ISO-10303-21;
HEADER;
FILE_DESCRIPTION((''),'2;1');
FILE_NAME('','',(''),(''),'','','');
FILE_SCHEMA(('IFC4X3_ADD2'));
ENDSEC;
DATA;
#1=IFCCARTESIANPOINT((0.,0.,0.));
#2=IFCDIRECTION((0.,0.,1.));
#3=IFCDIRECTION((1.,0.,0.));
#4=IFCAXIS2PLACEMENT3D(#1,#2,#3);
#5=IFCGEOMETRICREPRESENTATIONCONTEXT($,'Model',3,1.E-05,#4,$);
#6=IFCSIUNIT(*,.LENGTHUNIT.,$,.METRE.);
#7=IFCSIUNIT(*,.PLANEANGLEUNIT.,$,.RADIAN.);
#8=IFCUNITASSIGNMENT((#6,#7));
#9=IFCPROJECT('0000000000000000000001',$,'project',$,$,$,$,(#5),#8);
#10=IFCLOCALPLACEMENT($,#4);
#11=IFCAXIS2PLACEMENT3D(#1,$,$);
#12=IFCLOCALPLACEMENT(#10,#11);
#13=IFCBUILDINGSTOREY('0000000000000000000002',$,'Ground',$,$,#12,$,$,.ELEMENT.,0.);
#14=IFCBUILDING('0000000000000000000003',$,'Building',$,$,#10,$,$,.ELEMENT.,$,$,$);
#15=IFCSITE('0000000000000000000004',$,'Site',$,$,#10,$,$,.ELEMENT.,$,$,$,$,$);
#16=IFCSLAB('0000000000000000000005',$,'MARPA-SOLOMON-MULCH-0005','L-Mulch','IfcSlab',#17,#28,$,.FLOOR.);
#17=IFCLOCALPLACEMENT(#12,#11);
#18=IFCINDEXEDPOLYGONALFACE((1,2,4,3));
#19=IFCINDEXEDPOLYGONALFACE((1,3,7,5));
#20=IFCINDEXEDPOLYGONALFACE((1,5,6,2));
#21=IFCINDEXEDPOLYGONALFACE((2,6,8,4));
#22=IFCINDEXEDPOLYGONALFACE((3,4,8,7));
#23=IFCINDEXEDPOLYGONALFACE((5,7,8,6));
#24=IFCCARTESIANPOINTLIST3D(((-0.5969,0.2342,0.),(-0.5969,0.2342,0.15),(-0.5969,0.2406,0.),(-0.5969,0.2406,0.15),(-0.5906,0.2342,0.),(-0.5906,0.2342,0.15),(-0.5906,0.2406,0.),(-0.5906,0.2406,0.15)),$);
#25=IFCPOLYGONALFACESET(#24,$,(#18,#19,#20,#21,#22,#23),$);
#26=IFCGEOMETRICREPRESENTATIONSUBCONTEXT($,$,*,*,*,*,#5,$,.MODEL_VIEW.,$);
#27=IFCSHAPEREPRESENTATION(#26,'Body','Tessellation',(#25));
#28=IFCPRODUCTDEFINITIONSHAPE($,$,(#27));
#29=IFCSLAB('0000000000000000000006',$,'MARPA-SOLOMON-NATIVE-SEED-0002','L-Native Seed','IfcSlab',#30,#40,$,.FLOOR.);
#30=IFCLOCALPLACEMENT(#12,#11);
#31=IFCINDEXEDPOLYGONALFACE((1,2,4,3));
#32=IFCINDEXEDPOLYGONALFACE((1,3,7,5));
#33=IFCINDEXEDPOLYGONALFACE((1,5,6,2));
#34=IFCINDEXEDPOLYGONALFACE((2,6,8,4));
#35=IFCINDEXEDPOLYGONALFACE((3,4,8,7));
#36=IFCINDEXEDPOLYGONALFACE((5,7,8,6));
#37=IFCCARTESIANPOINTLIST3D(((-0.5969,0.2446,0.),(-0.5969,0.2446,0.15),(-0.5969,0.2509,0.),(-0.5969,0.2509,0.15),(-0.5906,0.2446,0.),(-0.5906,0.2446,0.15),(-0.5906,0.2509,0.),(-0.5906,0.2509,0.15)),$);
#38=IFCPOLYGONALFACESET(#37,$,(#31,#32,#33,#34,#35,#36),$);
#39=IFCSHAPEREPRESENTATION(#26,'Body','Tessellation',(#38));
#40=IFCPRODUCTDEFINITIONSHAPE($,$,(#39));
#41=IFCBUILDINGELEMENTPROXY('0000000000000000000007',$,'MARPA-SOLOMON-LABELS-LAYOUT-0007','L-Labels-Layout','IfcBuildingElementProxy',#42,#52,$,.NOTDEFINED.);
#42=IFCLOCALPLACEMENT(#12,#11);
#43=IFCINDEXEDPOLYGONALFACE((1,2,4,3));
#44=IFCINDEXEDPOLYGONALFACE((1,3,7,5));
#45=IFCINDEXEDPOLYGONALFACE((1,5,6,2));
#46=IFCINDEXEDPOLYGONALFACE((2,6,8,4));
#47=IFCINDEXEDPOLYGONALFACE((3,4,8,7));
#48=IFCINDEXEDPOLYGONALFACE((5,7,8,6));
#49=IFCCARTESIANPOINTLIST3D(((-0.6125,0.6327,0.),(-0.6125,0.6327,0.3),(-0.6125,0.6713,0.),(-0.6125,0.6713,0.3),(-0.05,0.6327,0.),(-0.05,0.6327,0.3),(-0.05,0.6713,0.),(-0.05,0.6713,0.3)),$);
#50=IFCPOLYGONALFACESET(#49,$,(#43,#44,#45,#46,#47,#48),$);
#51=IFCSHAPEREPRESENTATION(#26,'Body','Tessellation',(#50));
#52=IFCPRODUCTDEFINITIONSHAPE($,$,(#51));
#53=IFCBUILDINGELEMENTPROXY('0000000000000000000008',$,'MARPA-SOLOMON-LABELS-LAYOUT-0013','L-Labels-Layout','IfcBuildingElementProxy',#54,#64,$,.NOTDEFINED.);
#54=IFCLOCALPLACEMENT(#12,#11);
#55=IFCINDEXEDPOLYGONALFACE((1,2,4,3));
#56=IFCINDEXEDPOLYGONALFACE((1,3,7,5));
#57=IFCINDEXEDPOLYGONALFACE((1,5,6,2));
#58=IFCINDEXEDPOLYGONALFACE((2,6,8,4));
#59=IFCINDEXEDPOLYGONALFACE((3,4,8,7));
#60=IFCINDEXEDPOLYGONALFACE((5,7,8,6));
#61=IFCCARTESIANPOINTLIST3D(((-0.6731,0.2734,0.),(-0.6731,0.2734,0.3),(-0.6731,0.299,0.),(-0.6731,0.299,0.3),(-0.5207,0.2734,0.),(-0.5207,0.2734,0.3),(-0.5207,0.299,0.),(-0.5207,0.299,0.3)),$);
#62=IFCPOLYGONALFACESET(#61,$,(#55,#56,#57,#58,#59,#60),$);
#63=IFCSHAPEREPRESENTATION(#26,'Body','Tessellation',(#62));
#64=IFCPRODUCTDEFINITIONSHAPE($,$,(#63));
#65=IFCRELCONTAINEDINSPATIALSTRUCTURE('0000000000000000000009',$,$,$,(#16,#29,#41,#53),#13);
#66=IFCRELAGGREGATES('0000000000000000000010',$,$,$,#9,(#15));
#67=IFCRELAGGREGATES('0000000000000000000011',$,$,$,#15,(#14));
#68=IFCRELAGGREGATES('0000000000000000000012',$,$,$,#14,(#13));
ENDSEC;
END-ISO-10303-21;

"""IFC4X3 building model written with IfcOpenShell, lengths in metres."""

from ifc_helpers import new_model, si_unit, frame, origin, origin_with_axes, place, context, subcontext, project, spatial, polyline, outline, extrude, element, save


model = new_model("IFC4X3")

# Units and contexts
model_context = context("Model", 3, precision=1e-05, world=origin_with_axes())
sub_context = subcontext(model_context, None, None, "MODEL_VIEW")
ifc_project = project(units=[si_unit("LENGTHUNIT", "METRE"), si_unit("PLANEANGLEUNIT", "RADIAN")], contexts=[model_context])

# Site, building, storey
placement = place(None, origin_with_axes())
site = spatial("IfcSite", under=ifc_project, at=placement, Name="Site", CompositionType="ELEMENT")
building = spatial("IfcBuilding", under=site, at=placement, Name="Building", CompositionType="ELEMENT")
storey_placement = place(placement, origin())
storey = spatial("IfcBuildingStorey", under=building, at=storey_placement, Name="Ground", CompositionType="ELEMENT", Elevation=0.0)

# Slabs
for number, where, name, description in (
    (1, (-0.5969, 0.2342, 0.0), "MARPA-SOLOMON-MULCH-0005", "L-Mulch"),
    (2, (-0.5969, 0.2446, 0.0), "MARPA-SOLOMON-NATIVE-SEED-0002", "L-Native Seed"),
):
    element("IfcSlab", number, at=place(storey_placement, frame(where)), inside=storey, Name=name, Description=description, ObjectType="IfcSlab", PredefinedType="FLOOR", context=sub_context, shape_type="SweptSolid", body=[
        extrude(outline(polyline([(0.0, 0.0063), (0.0063, 0.0063), (0.0063, 0.0), (0.0, 0.0), (0.0, 0.0063)])), origin(), (0.0, 0.0, 1.0), 0.15),
    ])

# Building element proxies
proxy_1_placement = place(placement, frame((-0.6125, 0.6327, 0.0)))
element("IfcBuildingElementProxy", 3, at=proxy_1_placement, inside=storey, Name="MARPA-SOLOMON-LABELS-LAYOUT-0007", Description="L-Labels-Layout", ObjectType="IfcBuildingElementProxy", PredefinedType="NOTDEFINED", context=sub_context, shape_type="SweptSolid", body=[
    extrude(outline(polyline([(0.0, 0.0385), (0.5625, 0.0385), (0.5625, 0.0), (0.0, 0.0), (0.0, 0.0385)])), origin(), (0.0, 0.0, 1.0), 0.3),
])
for number, where, name in (
    (4, (-0.6731, 0.2734, 0.0), "MARPA-SOLOMON-LABELS-LAYOUT-0013"),
):
    element("IfcBuildingElementProxy", number, at=place(placement, frame(where)), inside=storey, Name=name, Description="L-Labels-Layout", ObjectType="IfcBuildingElementProxy", PredefinedType="NOTDEFINED", context=sub_context, shape_type="SweptSolid", body=[
        extrude(outline(polyline([(0.0, 0.0256), (0.1524, 0.0256), (0.1524, 0.0), (0.0, 0.0), (0.0, 0.0256)])), origin(), (0.0, 0.0, 1.0), 0.3),
    ])

save(model, "model.ifc")
